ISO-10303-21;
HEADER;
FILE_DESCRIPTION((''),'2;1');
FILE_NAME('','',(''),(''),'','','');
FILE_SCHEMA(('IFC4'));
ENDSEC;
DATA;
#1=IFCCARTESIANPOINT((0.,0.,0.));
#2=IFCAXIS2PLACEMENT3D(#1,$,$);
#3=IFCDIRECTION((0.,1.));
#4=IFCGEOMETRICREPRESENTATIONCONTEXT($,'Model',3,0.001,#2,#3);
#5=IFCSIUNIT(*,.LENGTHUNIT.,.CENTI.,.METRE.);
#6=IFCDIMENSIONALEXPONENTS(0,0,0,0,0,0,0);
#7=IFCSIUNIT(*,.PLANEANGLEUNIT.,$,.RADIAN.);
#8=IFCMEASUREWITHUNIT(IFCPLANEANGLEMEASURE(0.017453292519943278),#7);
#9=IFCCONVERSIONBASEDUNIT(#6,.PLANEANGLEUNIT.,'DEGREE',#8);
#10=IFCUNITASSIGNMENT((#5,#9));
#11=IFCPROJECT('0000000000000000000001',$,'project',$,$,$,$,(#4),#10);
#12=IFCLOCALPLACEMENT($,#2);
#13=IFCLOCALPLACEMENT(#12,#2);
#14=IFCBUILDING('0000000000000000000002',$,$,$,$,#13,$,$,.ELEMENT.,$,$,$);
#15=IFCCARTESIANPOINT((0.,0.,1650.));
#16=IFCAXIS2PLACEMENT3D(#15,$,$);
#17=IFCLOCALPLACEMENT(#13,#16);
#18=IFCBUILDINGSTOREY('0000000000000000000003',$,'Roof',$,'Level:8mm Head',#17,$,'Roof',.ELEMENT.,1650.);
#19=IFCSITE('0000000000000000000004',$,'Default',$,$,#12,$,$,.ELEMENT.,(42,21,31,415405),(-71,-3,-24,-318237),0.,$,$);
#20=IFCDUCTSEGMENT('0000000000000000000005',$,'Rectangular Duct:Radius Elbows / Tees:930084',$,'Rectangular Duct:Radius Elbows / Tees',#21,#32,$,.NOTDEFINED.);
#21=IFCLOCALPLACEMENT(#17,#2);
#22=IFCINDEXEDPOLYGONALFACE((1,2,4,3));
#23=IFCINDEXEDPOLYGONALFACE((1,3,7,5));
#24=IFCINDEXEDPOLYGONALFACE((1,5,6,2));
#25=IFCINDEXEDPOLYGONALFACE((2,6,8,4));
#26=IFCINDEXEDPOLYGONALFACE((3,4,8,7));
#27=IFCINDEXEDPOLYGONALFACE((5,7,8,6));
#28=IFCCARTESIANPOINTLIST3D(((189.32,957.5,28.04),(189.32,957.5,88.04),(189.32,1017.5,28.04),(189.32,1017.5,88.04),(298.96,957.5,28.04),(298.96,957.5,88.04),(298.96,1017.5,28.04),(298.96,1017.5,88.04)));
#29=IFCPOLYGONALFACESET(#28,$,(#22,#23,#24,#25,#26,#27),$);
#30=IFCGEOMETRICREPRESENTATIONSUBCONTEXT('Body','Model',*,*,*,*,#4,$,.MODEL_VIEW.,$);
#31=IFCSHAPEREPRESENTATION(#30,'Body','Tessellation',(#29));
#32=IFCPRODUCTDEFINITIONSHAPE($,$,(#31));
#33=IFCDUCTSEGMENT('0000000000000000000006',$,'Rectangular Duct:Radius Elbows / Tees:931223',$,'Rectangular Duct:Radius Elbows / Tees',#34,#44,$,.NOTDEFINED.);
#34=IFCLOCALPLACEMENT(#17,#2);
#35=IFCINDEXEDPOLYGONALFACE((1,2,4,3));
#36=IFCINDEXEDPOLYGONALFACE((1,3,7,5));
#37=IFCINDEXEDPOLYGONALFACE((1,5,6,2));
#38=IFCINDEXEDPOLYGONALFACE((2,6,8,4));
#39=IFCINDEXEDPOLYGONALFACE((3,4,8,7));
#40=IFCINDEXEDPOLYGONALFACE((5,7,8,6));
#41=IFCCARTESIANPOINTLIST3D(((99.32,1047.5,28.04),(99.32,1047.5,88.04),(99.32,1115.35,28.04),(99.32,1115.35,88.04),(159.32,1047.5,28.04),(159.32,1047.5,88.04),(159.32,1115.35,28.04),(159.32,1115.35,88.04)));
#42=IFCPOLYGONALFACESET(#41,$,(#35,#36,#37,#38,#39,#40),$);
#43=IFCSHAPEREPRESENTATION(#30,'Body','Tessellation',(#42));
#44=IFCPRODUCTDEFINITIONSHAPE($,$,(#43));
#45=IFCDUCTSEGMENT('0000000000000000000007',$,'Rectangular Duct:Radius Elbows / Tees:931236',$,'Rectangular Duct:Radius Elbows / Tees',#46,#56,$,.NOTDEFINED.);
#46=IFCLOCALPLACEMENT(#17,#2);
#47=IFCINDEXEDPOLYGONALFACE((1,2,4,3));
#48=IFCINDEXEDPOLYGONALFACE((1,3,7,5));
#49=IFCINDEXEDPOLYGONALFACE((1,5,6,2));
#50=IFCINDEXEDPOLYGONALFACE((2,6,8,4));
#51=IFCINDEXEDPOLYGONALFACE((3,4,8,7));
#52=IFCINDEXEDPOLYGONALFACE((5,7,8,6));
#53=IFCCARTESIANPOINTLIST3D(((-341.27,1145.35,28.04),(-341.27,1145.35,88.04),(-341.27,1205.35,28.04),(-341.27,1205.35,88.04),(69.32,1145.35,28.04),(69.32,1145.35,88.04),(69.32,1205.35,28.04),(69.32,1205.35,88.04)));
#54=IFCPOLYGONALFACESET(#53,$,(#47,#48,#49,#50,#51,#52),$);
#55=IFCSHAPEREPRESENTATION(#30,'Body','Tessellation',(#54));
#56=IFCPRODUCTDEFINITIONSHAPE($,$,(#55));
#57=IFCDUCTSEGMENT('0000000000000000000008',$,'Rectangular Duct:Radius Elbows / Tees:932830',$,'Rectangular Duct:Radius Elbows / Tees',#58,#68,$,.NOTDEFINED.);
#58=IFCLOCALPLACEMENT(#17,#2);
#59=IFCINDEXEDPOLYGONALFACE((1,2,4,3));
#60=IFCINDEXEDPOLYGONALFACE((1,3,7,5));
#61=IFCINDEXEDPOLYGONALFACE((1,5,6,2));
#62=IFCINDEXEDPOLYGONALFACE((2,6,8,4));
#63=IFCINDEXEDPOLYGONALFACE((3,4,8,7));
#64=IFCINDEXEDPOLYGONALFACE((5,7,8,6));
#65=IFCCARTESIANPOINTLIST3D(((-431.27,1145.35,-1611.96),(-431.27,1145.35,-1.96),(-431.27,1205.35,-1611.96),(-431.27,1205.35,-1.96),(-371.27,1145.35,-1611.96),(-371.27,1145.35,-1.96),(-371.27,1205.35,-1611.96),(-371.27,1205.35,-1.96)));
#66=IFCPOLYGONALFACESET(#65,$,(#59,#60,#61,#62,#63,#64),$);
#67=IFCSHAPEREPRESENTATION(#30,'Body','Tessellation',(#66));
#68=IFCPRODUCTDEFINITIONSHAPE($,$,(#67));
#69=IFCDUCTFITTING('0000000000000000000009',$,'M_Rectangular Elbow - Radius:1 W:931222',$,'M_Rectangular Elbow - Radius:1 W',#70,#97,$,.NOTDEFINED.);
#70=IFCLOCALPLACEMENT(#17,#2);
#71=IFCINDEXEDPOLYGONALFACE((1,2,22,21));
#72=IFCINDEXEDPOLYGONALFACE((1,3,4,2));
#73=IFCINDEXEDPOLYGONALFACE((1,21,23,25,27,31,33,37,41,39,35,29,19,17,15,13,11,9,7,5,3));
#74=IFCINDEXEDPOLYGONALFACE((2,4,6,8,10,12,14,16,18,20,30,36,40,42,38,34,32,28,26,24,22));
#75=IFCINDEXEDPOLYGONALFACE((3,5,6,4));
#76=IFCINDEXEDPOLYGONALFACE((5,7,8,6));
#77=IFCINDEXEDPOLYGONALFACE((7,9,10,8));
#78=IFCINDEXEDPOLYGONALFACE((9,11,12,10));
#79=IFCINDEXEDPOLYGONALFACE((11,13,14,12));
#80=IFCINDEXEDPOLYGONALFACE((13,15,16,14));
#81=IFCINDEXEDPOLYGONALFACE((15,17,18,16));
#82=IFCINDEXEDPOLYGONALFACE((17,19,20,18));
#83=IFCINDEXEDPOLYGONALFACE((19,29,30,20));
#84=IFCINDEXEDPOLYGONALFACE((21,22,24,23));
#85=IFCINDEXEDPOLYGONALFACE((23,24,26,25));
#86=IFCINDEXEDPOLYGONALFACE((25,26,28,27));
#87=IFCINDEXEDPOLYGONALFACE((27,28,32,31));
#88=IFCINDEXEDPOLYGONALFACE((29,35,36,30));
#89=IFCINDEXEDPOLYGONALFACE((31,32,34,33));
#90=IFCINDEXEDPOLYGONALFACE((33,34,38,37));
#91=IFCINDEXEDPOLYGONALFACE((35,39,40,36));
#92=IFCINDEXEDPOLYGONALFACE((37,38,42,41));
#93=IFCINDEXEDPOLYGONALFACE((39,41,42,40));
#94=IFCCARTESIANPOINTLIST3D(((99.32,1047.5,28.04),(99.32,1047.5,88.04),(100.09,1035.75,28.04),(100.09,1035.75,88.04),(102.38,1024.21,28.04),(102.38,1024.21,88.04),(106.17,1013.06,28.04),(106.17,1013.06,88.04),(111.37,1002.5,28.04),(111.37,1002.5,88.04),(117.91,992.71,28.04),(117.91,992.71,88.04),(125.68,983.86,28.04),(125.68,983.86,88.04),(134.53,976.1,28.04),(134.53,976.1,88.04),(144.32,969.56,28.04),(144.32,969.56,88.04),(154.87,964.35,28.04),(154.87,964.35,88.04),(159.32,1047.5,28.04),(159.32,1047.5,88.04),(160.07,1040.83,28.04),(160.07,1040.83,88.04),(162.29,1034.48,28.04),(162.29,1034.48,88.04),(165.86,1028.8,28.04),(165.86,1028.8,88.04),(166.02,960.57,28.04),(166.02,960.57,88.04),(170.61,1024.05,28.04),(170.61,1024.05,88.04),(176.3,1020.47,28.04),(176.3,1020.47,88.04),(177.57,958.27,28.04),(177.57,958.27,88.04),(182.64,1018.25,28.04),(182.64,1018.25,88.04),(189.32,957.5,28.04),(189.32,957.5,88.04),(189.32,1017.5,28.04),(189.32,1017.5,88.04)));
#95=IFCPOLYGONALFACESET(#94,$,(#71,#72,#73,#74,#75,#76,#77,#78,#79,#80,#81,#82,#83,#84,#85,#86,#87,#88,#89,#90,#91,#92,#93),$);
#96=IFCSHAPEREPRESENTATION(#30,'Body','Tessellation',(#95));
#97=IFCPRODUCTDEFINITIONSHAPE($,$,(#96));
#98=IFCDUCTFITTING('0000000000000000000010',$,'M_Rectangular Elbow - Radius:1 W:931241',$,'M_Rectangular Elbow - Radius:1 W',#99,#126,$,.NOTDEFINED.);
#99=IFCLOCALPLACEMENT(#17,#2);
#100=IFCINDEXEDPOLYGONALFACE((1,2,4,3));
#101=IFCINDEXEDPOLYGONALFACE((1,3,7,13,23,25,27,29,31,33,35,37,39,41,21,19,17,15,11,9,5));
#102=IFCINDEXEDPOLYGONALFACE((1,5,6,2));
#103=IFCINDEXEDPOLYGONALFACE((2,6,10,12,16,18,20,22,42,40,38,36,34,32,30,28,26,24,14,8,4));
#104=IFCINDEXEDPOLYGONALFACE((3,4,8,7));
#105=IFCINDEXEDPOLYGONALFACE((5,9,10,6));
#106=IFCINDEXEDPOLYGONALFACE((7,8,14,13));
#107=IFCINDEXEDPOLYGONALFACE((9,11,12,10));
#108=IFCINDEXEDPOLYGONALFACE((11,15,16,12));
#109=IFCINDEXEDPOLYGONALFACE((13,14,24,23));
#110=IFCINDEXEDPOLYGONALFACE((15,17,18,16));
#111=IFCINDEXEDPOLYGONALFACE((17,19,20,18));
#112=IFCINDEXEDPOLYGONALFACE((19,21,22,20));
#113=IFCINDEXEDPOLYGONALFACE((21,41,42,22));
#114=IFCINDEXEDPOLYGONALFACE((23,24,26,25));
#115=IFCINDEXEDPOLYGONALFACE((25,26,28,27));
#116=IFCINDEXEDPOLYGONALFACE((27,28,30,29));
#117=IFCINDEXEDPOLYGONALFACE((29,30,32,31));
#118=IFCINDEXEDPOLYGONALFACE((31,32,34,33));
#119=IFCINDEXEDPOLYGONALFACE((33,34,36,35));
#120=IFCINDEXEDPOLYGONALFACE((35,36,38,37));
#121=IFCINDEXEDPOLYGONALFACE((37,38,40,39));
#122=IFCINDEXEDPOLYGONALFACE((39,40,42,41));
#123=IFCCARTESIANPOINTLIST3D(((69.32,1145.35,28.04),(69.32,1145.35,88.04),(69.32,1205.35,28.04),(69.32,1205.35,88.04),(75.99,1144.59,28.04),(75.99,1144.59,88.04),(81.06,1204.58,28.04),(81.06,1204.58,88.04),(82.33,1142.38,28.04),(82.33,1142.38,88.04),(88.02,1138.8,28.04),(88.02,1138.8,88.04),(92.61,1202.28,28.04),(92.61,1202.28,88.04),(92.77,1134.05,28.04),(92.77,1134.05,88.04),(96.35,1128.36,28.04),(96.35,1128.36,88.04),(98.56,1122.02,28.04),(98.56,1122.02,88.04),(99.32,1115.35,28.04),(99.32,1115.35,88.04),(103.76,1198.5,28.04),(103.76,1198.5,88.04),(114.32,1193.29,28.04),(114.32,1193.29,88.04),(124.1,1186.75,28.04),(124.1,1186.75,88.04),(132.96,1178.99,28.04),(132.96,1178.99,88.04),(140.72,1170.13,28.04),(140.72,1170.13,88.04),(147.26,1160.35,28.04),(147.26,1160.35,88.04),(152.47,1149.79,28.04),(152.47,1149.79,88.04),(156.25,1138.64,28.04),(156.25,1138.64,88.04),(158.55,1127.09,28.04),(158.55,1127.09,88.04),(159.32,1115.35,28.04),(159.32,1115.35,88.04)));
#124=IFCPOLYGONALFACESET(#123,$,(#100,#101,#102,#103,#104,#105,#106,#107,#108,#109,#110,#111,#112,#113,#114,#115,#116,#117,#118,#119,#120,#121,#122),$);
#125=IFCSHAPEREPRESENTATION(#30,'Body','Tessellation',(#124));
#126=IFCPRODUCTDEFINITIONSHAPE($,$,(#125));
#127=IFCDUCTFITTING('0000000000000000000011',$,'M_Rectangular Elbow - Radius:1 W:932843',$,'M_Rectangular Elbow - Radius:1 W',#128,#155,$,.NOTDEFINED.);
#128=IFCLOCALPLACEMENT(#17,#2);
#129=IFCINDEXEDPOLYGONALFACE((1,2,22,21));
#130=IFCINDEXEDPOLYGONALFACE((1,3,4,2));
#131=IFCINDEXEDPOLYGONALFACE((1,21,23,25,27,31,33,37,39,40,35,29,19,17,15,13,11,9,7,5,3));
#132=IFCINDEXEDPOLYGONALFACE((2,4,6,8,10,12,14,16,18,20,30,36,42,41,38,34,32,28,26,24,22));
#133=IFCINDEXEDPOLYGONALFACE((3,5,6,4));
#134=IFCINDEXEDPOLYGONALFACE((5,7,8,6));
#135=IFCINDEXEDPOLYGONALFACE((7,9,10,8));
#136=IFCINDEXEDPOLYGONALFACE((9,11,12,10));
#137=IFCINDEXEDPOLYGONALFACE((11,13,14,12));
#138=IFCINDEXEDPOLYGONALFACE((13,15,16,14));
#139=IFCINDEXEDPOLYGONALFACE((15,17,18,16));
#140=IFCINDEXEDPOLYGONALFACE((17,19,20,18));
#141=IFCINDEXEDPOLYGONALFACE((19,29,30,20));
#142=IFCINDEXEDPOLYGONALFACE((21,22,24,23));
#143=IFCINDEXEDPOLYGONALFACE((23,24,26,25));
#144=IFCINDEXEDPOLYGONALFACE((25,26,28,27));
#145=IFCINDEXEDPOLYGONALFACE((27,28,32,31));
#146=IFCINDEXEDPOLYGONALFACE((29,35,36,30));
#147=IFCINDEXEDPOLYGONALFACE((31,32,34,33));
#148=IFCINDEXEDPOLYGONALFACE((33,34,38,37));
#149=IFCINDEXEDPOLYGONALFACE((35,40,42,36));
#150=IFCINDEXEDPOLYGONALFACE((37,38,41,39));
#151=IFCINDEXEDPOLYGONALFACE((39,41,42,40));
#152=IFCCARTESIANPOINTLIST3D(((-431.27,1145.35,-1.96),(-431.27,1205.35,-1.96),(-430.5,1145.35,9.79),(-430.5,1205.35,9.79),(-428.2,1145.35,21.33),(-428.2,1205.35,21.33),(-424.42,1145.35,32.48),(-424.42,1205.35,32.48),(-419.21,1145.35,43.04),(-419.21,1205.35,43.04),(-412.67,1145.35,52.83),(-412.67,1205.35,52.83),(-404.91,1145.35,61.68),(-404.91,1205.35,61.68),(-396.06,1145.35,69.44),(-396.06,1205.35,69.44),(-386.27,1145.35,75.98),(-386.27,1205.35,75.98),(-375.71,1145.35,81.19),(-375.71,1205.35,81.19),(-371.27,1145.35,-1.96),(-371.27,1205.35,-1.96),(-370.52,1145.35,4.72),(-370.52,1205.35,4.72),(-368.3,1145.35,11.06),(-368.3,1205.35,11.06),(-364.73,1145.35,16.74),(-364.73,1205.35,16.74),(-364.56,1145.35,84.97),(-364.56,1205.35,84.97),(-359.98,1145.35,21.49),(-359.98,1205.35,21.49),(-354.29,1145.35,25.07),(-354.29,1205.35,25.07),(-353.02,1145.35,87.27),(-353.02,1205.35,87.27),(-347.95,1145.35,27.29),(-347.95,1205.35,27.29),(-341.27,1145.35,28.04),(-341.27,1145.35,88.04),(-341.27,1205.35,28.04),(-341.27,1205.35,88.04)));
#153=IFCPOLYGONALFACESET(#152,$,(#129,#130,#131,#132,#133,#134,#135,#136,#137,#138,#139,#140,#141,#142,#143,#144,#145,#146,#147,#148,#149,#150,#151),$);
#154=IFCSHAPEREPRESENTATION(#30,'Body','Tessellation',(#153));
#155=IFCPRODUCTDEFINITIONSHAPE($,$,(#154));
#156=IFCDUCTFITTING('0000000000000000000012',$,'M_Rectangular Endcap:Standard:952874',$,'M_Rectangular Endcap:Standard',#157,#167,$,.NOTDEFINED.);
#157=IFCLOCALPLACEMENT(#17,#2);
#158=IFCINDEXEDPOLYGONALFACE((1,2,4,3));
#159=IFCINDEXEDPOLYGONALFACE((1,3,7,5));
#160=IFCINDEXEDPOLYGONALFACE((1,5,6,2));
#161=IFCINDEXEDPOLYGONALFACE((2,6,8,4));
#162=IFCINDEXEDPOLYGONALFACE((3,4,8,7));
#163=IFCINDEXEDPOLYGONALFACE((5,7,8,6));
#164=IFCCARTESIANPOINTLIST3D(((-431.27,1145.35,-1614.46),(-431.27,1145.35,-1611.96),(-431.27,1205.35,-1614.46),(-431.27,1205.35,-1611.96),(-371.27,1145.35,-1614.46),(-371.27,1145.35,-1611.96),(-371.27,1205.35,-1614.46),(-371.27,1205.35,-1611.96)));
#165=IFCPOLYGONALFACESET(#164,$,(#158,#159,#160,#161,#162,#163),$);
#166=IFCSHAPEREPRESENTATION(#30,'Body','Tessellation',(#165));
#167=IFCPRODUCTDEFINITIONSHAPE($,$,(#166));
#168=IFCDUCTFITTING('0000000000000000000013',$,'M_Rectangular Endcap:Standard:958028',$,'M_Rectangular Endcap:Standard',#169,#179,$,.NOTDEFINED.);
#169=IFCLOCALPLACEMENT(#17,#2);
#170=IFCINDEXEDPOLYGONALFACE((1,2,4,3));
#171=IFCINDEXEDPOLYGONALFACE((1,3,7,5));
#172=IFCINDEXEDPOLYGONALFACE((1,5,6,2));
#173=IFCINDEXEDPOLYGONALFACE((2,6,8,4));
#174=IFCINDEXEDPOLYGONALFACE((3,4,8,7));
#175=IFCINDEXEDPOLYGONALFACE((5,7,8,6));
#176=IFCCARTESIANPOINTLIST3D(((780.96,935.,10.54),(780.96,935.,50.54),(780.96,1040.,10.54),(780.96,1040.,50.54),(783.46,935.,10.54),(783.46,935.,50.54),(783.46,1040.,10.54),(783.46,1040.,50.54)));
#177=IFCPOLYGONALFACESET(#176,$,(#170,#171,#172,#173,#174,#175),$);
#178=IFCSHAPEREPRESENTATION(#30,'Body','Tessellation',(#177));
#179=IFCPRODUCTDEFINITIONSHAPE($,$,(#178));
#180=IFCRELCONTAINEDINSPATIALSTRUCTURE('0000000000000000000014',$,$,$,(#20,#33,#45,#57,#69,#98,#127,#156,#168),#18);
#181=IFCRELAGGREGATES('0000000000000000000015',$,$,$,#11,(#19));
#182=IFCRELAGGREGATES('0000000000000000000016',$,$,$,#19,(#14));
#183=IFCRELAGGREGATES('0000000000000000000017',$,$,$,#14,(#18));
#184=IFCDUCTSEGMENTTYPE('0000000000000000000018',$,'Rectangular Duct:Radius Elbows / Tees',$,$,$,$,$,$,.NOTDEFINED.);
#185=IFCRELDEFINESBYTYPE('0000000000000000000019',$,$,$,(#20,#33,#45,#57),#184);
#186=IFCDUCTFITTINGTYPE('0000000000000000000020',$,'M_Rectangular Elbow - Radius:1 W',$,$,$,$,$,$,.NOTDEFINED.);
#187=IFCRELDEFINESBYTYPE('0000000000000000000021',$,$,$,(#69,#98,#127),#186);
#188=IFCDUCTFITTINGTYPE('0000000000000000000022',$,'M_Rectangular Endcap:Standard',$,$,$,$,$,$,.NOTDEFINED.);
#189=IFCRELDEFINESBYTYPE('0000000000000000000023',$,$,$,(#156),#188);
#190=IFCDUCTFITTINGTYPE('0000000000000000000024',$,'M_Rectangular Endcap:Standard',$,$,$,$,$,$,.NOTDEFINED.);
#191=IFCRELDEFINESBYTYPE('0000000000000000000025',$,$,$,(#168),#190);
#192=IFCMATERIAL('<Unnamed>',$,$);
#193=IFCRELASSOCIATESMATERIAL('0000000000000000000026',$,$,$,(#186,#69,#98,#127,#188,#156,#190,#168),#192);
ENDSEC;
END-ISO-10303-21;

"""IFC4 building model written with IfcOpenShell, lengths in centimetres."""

from ifc_helpers import new_model, entity, si_unit, converted_unit, direction, frame, origin, place, context, subcontext, project, spatial, line, arc, indexed_curve, outline, extrude, source, transform, mapped, material, type_object, type_shapes, element, save


model = new_model("IFC4")

# Units and contexts
model_context = context("Model", 3, precision=0.001, world=origin(), true_north=direction((0.0, 1.0)))
body_context = subcontext(model_context, "Body", "Model", "MODEL_VIEW")
ifc_project = project(units=[si_unit("LENGTHUNIT", "METRE", prefix="CENTI"), converted_unit("PLANEANGLEUNIT", "DEGREE", entity("IfcPlaneAngleMeasure", 0.017453292519943278), si_unit("PLANEANGLEUNIT", "RADIAN"), dimensions=[0, 0, 0, 0, 0, 0, 0])], contexts=[model_context])

# Site, building, storey
site_placement = place(None, origin())
site = spatial("IfcSite", under=ifc_project, at=site_placement, Name="Default", CompositionType="ELEMENT", RefLatitude=(42, 21, 31, 415405), RefLongitude=(-71, -3, -24, -318237), RefElevation=0.0)
building_placement = place(site_placement, origin())
building = spatial("IfcBuilding", under=site, at=building_placement, CompositionType="ELEMENT")
storey_placement = place(building_placement, frame((0.0, 0.0, 1650.0)))
storey = spatial("IfcBuildingStorey", under=building, at=storey_placement, Name="Roof", ObjectType="Level:8mm Head", LongName="Roof", CompositionType="ELEMENT", Elevation=1650.0)

# Duct segments
duct_segment_type = type_object("IfcDuctSegmentType", Name="Rectangular Duct:Radius Elbows / Tees", PredefinedType="NOTDEFINED")
duct_segment_1_placement = place(storey_placement, origin())
element("IfcDuctSegment", 1, at=duct_segment_1_placement, inside=storey, type_object=duct_segment_type, Name="Rectangular Duct:Radius Elbows / Tees:930084", ObjectType="Rectangular Duct:Radius Elbows / Tees", PredefinedType="NOTDEFINED", context=body_context, shape_type="SweptSolid", body=[
    extrude(outline(indexed_curve([(-54.82, -30.0), (54.82, -30.0), (54.82, 30.0), (-54.82, 30.0), (-54.82, -30.0)], self_intersect=False)), frame((244.14, 987.5, 28.04), z_axis=(0.0, 0.0, 1.0), x_axis=(-1.0, 0.0, 0.0)), (0.0, 0.0, 1.0), 60.0),
])
duct_segment_2_placement = place(storey_placement, origin())
element("IfcDuctSegment", 2, at=duct_segment_2_placement, inside=storey, type_object=duct_segment_type, Name="Rectangular Duct:Radius Elbows / Tees:931223", ObjectType="Rectangular Duct:Radius Elbows / Tees", PredefinedType="NOTDEFINED", context=body_context, shape_type="SweptSolid", body=[
    extrude(outline(indexed_curve([(-33.92, -30.0), (33.92, -30.0), (33.92, 30.0), (-33.92, 30.0), (-33.92, -30.0)], self_intersect=False)), frame((129.32, 1081.42, 28.04), z_axis=(0.0, 0.0, 1.0), x_axis=(0.0, 1.0, 0.0)), (0.0, 0.0, 1.0), 60.0),
])
duct_segment_3_placement = place(storey_placement, origin())
element("IfcDuctSegment", 3, at=duct_segment_3_placement, inside=storey, type_object=duct_segment_type, Name="Rectangular Duct:Radius Elbows / Tees:931236", ObjectType="Rectangular Duct:Radius Elbows / Tees", PredefinedType="NOTDEFINED", context=body_context, shape_type="SweptSolid", body=[
    extrude(outline(indexed_curve([(-205.29, -30.0), (205.29, -30.0), (205.29, 30.0), (-205.29, 30.0), (-205.29, -30.0)], self_intersect=False)), frame((-135.98, 1175.35, 28.04), z_axis=(0.0, 0.0, 1.0), x_axis=(-1.0, 0.0, 0.0)), (0.0, 0.0, 1.0), 60.0),
])
duct_segment_4_placement = place(storey_placement, origin())
element("IfcDuctSegment", 4, at=duct_segment_4_placement, inside=storey, type_object=duct_segment_type, Name="Rectangular Duct:Radius Elbows / Tees:932830", ObjectType="Rectangular Duct:Radius Elbows / Tees", PredefinedType="NOTDEFINED", context=body_context, shape_type="SweptSolid", body=[
    extrude(outline(indexed_curve([(-30.0, -30.0), (30.0, -30.0), (30.0, 30.0), (-30.0, 30.0), (-30.0, -30.0)], self_intersect=False)), frame((-401.27, 1175.35, -1611.96), z_axis=(0.0, 0.0, 1.0), x_axis=(0.0, 1.0, 0.0)), (0.0, 0.0, 1.0), 1610.0),
])

# Duct fittings
ifc_material = material(Name="<Unnamed>")
duct_fitting_type_1 = type_object("IfcDuctFittingType", Name="M_Rectangular Elbow - Radius:1 W", PredefinedType="NOTDEFINED", material=ifc_material)
shared_shape_1 = source(origin(), body_context, "Body", "SweptSolid", [
    extrude(outline(indexed_curve([(-60.0, -30.0), (0.0, -30.0), (8.79, -8.79), (30.0, 0.0), (30.0, 60.0), (-33.64, 33.64)], segments=[line(1, 2), arc(2, 3, 4), line(4, 5), arc(5, 6, 1)], self_intersect=False)), frame((-30.0, 30.0, -30.0), z_axis=(0.0, 0.0, 1.0), x_axis=(-1.0, 0.0, 0.0)), (0.0, 0.0, 1.0), 60.0),
])
type_shapes(duct_fitting_type_1, [shared_shape_1])
for number, where, z_axis, x_axis, name in (
    (5, (129.32, 987.5, 58.04), (0.0, 0.0, 1.0), (0.0, -1.0, 0.0), "M_Rectangular Elbow - Radius:1 W:931222"),
    (6, (129.32, 1175.35, 58.04), (0.0, 0.0, 1.0), (0.0, 1.0, 0.0), "M_Rectangular Elbow - Radius:1 W:931241"),
    (7, (-401.27, 1175.35, 58.04), (0.0, -1.0, 0.0), (-1.0, 0.0, 0.0), "M_Rectangular Elbow - Radius:1 W:932843"),
):
    element("IfcDuctFitting", number, at=place(storey_placement, frame(where, z_axis=z_axis, x_axis=x_axis)), inside=storey, type_object=duct_fitting_type_1, material=ifc_material, Name=name, ObjectType="M_Rectangular Elbow - Radius:1 W", PredefinedType="NOTDEFINED", context=body_context, shape_type="MappedRepresentation", body=[
        mapped(shared_shape_1, transform((0.0, 0.0, 0.0), scale=1.0)),
    ])
duct_fitting_type_2 = type_object("IfcDuctFittingType", Name="M_Rectangular Endcap:Standard", PredefinedType="NOTDEFINED", material=ifc_material)
shared_shape_2 = source(origin(), body_context, "Body", "SweptSolid", [
    extrude(outline(indexed_curve([(-1.25, -30.0), (1.25, -30.0), (1.25, 30.0), (-1.25, 30.0), (-1.25, -30.0)], self_intersect=False)), frame((1.25, 0.0, -30.0)), (0.0, 0.0, 1.0), 60.0),
])
type_shapes(duct_fitting_type_2, [shared_shape_2])
duct_fitting_1_placement = place(storey_placement, frame((-401.27, 1175.35, -1611.96), z_axis=(-1.0, 0.0, 0.0), x_axis=(0.0, 0.0, -1.0)))
element("IfcDuctFitting", 8, at=duct_fitting_1_placement, inside=storey, type_object=duct_fitting_type_2, material=ifc_material, Name="M_Rectangular Endcap:Standard:952874", ObjectType="M_Rectangular Endcap:Standard", PredefinedType="NOTDEFINED", context=body_context, shape_type="MappedRepresentation", body=[
    mapped(shared_shape_2, transform((0.0, 0.0, 0.0), scale=1.0)),
])
duct_fitting_type_3 = type_object("IfcDuctFittingType", Name="M_Rectangular Endcap:Standard", PredefinedType="NOTDEFINED", material=ifc_material)
shared_shape_3 = source(origin(), body_context, "Body", "SweptSolid", [
    extrude(outline(indexed_curve([(-1.25, -52.5), (1.25, -52.5), (1.25, 52.5), (-1.25, 52.5), (-1.25, -52.5)], self_intersect=False)), frame((1.25, 0.0, -20.0)), (0.0, 0.0, 1.0), 40.0),
])
type_shapes(duct_fitting_type_3, [shared_shape_3])
duct_fitting_2_placement = place(storey_placement, frame((780.96, 987.5, 30.54)))
element("IfcDuctFitting", 9, at=duct_fitting_2_placement, inside=storey, type_object=duct_fitting_type_3, material=ifc_material, Name="M_Rectangular Endcap:Standard:958028", ObjectType="M_Rectangular Endcap:Standard", PredefinedType="NOTDEFINED", context=body_context, shape_type="MappedRepresentation", body=[
    mapped(shared_shape_3, transform((0.0, 0.0, 0.0), scale=1.0)),
])

save(model, "model.ifc")
